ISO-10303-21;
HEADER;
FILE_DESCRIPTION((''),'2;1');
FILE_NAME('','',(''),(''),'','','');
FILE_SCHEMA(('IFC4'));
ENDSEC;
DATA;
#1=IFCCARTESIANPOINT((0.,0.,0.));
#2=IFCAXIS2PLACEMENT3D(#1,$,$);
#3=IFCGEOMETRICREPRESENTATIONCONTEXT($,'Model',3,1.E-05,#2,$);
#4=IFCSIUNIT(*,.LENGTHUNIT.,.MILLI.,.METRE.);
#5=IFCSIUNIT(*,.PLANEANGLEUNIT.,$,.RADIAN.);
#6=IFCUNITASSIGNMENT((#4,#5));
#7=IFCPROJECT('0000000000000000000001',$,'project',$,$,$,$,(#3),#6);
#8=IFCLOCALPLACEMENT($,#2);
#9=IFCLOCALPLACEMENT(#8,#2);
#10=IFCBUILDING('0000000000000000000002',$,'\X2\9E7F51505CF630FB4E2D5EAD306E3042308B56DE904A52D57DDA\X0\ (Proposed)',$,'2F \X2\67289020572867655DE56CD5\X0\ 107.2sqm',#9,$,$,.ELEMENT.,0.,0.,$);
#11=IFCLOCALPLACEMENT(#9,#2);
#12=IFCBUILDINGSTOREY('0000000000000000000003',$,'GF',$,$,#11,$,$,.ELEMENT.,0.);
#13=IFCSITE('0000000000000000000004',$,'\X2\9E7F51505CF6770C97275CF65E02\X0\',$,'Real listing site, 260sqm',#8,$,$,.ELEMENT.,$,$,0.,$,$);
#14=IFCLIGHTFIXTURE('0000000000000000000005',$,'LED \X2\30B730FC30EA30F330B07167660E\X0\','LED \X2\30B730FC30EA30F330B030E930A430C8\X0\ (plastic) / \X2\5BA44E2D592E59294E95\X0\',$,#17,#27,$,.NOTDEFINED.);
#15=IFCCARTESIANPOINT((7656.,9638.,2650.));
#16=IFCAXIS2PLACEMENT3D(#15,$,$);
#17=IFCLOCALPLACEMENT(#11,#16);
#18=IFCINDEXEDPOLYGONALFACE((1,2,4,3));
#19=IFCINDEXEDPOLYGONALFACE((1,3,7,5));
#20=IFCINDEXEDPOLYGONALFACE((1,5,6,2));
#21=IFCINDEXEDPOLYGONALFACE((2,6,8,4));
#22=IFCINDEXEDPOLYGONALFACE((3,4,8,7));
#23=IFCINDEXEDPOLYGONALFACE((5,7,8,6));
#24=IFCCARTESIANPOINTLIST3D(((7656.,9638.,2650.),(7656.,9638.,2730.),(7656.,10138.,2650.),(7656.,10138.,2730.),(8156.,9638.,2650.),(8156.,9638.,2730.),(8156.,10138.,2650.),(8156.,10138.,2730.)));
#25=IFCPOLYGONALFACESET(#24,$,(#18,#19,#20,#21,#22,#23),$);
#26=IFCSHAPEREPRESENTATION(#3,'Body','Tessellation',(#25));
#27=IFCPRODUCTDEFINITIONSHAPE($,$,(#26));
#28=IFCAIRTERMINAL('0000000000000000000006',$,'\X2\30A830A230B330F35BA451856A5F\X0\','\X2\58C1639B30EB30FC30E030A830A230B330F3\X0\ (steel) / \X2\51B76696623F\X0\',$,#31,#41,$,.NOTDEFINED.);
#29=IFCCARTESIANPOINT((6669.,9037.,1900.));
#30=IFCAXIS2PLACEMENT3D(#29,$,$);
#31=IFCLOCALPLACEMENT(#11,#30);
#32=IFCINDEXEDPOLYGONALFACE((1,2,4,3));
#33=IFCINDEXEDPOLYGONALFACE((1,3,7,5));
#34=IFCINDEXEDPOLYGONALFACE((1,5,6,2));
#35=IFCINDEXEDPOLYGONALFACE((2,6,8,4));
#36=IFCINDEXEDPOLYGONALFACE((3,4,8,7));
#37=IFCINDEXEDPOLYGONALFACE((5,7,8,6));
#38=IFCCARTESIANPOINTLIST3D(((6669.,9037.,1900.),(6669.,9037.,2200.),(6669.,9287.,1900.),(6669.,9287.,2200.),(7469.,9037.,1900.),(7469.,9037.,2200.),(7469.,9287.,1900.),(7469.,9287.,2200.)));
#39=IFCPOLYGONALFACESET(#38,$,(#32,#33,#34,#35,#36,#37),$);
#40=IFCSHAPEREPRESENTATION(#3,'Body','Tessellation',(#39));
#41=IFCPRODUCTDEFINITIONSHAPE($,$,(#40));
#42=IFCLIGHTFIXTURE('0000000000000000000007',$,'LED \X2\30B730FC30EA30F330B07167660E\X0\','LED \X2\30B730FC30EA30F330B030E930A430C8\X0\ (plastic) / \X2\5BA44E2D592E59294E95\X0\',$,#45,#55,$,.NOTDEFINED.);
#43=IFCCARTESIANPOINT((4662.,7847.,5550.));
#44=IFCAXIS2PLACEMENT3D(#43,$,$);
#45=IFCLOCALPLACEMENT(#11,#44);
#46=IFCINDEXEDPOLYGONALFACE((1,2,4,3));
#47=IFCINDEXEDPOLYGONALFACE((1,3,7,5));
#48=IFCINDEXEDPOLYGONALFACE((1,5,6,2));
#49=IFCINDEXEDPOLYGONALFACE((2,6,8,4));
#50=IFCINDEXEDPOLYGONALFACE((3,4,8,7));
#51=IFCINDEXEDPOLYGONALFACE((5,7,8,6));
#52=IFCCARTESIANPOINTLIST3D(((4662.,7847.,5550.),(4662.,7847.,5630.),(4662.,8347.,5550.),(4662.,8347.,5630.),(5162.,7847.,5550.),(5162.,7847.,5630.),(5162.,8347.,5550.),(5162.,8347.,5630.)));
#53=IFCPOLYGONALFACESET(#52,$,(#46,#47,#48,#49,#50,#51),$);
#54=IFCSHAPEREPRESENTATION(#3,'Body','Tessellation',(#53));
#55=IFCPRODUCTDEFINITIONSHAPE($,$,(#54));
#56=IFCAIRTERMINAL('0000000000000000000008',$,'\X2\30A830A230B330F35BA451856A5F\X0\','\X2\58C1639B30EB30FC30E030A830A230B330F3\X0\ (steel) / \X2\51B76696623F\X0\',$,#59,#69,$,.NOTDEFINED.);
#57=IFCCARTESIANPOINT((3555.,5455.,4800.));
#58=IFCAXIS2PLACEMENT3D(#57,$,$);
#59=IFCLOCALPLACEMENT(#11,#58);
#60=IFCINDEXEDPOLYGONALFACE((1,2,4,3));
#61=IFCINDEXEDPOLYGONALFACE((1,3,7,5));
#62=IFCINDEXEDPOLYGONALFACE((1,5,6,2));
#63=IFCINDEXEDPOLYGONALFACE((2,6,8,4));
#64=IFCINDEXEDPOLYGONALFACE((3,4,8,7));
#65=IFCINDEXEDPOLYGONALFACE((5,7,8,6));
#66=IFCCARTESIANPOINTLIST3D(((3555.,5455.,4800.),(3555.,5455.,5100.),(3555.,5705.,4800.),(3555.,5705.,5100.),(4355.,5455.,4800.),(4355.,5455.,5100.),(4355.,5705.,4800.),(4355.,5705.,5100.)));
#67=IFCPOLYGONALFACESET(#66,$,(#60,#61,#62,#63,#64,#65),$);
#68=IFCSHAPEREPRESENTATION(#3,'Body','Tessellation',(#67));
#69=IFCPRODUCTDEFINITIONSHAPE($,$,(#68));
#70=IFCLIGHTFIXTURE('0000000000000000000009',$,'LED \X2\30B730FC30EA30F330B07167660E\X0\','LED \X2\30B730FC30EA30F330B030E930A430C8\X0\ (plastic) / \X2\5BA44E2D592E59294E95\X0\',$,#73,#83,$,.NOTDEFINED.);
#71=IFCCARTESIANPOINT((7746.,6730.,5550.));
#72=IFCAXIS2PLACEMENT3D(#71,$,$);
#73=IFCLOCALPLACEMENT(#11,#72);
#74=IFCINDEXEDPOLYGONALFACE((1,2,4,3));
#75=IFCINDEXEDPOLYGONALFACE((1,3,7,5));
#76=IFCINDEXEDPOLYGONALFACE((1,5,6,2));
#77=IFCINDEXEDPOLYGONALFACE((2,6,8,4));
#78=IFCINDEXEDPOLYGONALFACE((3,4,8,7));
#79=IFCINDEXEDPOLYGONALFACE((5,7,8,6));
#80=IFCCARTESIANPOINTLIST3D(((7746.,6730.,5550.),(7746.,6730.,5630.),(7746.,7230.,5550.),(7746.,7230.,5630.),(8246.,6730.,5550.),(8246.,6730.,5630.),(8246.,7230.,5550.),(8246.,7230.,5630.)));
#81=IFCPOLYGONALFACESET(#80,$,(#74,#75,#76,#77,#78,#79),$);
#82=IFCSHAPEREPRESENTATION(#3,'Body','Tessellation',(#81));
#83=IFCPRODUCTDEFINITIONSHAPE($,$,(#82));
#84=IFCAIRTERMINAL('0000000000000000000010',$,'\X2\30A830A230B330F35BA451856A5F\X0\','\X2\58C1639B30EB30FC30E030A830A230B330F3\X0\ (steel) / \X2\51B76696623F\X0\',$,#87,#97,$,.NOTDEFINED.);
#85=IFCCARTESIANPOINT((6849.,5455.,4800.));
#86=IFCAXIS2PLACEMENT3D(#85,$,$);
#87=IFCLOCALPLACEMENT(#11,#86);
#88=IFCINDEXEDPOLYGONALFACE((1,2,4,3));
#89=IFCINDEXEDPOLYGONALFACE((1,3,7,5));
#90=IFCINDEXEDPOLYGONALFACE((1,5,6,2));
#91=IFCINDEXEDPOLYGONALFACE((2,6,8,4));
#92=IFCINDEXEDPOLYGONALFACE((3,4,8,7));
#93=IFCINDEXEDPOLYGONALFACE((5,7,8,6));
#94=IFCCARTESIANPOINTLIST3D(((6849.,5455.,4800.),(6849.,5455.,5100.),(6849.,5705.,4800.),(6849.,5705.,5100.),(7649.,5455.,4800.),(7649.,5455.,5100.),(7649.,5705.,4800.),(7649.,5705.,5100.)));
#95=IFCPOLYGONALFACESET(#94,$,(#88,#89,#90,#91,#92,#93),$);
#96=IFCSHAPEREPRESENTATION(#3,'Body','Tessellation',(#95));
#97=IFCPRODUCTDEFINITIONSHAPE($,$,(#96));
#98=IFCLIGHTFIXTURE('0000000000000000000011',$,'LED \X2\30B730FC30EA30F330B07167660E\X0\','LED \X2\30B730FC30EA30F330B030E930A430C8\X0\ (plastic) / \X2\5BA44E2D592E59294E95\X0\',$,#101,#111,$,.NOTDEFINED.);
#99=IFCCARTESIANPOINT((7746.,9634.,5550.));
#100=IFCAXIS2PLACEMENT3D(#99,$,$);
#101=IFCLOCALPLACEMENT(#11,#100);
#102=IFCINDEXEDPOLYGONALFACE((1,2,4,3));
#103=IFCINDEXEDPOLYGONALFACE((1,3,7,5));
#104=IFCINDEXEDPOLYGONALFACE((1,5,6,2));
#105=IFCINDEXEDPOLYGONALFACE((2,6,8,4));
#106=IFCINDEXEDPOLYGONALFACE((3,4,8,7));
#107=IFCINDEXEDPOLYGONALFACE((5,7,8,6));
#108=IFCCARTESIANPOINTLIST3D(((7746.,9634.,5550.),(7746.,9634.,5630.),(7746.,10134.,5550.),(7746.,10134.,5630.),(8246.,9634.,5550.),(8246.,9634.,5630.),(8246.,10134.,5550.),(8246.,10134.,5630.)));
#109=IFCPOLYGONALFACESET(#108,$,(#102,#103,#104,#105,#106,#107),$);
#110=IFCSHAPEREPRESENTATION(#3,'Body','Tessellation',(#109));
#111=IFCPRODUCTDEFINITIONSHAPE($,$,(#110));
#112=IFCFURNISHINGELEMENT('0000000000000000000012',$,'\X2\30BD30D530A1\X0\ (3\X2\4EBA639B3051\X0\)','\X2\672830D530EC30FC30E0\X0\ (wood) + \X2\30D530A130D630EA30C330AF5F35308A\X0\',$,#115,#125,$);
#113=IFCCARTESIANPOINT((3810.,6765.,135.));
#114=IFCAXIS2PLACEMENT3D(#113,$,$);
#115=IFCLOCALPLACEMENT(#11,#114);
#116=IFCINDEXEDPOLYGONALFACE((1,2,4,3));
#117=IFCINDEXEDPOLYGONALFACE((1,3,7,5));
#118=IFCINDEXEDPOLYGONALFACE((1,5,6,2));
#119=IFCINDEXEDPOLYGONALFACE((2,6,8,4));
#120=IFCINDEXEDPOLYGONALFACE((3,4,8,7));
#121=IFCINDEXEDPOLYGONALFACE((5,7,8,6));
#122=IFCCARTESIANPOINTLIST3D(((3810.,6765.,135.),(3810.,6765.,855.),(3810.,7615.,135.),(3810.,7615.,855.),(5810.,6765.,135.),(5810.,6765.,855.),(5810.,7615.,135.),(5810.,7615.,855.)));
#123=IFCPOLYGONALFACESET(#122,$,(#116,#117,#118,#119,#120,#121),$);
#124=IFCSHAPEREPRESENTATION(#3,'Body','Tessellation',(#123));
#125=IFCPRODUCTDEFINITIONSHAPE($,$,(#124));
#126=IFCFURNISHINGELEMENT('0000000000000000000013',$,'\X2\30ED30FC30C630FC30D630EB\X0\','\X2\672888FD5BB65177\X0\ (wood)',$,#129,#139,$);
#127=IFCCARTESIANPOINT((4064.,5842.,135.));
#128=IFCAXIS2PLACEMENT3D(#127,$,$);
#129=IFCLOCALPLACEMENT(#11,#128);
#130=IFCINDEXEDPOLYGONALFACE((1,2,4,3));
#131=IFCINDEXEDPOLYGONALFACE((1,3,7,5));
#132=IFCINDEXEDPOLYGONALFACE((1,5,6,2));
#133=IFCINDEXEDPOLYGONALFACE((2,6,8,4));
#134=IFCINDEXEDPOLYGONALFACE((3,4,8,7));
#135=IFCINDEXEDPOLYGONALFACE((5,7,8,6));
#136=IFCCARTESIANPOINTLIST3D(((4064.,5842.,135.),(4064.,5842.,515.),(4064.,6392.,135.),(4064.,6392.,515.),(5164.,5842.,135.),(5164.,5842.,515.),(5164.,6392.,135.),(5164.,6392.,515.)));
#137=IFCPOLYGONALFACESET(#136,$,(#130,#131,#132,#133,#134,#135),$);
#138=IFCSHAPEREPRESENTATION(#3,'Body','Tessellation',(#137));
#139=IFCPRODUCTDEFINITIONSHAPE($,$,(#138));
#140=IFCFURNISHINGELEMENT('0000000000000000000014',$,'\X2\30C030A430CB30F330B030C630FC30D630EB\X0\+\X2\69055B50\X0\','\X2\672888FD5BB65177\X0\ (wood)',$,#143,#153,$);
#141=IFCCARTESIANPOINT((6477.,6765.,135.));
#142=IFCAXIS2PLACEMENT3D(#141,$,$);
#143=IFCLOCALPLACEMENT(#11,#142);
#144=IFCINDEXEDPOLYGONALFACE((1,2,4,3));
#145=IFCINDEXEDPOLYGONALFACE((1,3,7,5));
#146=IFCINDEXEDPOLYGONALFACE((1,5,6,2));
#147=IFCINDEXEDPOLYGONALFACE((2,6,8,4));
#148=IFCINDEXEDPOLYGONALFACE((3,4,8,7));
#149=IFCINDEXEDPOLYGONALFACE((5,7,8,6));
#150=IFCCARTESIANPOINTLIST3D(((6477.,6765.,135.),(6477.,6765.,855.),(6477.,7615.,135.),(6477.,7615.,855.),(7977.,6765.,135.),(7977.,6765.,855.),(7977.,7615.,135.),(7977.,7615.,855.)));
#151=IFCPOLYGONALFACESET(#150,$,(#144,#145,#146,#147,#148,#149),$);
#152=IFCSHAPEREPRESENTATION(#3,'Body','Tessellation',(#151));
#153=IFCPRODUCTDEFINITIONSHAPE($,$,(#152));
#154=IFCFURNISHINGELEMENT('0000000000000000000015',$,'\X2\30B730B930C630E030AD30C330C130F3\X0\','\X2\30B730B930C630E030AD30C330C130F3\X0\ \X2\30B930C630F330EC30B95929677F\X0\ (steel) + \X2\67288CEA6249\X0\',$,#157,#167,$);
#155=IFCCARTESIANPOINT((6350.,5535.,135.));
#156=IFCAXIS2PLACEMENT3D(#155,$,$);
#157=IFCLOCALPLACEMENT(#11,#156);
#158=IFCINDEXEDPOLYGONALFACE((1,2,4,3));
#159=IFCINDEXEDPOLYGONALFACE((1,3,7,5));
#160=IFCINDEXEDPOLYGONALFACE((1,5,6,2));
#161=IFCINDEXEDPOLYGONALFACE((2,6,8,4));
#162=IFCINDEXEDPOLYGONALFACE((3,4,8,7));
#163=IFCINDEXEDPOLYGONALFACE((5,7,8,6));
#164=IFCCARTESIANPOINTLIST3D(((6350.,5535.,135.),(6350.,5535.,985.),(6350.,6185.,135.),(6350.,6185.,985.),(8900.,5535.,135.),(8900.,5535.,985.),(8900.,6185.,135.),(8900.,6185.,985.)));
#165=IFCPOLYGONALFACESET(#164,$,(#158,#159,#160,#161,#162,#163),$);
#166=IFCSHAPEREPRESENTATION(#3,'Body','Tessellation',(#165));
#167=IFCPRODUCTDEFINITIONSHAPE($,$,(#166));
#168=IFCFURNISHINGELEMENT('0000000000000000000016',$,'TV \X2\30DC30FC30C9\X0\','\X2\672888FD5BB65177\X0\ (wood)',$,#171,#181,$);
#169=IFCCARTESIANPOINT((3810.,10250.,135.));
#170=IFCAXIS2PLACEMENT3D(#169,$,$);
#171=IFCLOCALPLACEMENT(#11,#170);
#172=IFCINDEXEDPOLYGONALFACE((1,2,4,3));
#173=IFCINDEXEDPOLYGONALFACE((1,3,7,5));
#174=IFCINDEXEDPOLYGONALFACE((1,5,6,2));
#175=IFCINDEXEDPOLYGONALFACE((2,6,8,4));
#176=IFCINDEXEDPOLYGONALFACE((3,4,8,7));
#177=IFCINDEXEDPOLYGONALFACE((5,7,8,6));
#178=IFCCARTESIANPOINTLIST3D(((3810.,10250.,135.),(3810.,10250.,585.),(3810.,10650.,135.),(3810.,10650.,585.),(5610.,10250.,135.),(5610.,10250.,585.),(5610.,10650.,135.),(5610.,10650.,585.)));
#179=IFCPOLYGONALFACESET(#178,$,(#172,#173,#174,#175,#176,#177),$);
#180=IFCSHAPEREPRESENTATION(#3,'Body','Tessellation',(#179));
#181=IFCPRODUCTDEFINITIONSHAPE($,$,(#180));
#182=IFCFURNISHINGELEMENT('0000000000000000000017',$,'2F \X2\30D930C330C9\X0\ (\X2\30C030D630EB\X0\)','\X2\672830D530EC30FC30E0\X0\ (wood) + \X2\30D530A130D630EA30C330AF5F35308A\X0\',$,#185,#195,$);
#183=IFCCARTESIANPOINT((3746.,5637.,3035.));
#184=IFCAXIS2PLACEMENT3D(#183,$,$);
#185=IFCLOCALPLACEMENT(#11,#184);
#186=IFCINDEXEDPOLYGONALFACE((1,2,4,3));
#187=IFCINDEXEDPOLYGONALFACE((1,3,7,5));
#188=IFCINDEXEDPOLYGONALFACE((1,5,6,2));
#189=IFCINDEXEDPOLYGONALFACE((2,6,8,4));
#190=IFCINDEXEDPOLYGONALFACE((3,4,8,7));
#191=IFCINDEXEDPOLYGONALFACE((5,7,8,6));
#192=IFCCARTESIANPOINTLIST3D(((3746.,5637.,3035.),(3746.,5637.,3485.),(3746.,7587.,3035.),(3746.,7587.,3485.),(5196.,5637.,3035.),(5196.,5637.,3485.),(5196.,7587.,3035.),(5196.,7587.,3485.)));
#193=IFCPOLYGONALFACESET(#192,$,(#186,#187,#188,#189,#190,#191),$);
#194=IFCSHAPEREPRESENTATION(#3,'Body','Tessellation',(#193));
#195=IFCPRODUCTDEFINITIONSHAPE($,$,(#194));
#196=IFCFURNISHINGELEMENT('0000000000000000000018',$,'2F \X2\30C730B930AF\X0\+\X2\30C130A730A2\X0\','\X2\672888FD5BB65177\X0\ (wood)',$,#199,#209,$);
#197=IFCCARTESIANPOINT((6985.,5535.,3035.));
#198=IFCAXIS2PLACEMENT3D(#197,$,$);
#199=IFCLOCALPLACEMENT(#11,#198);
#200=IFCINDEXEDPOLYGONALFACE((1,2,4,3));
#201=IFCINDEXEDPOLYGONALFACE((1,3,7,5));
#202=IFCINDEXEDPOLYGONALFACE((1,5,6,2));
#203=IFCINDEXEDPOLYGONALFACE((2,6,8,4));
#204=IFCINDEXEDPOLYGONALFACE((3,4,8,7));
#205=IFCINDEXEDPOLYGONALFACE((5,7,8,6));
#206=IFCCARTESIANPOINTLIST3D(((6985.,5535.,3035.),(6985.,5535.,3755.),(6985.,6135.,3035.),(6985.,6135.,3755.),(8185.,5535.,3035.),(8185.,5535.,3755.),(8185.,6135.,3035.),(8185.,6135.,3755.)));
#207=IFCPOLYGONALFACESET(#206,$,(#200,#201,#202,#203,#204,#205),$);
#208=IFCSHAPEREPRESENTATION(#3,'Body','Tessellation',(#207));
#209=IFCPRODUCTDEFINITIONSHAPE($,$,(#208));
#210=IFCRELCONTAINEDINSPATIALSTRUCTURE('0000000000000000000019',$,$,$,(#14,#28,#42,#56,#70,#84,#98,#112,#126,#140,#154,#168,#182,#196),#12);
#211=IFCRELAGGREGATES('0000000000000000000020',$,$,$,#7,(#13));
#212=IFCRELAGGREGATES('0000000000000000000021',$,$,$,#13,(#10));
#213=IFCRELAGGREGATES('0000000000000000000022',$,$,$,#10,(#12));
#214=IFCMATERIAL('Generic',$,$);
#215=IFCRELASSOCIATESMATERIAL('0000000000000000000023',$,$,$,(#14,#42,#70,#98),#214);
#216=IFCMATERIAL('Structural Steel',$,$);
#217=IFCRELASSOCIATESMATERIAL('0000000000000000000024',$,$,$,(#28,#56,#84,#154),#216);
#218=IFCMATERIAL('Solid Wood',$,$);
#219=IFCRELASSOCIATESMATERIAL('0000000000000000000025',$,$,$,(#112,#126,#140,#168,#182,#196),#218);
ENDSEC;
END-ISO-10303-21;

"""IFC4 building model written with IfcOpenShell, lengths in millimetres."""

from ifc_helpers import new_model, si_unit, frame, frame_2d, origin, place, context, project, spatial, rectangle, extrude, material, element, save


model = new_model("IFC4")

# Units and contexts
model_context = context("Model", 3, precision=1e-05, world=origin())
ifc_project = project(units=[si_unit("LENGTHUNIT", "METRE", prefix="MILLI"), si_unit("PLANEANGLEUNIT", "RADIAN")], contexts=[model_context])

# Site, building, storey
site_placement = place(None, origin())
site = spatial("IfcSite", under=ifc_project, at=site_placement, Name="鹿児島県霧島市", ObjectType="Real listing site, 260sqm", CompositionType="ELEMENT", RefElevation=0.0)
building_placement = place(site_placement, origin())
building = spatial("IfcBuilding", under=site, at=building_placement, Name="鹿児島・中庭のある回遊動線 (Proposed)", ObjectType="2F 木造在来工法 107.2sqm", CompositionType="ELEMENT", ElevationOfRefHeight=0.0, ElevationOfTerrain=0.0)
storey_placement = place(building_placement, origin())
storey = spatial("IfcBuildingStorey", under=building, at=storey_placement, Name="GF", CompositionType="ELEMENT", Elevation=0.0)

# Shared definitions
ifc_material_1 = material(Name="Solid Wood")

# Shared definitions
ifc_material_2 = material(Name="Structural Steel")

# Shared definitions
ifc_material_3 = material(Name="Generic")

# Light fixture
light_fixture_1_placement = place(storey_placement, frame((7656.0, 9638.0, 2650.0)))
element("IfcLightFixture", 1, at=light_fixture_1_placement, inside=storey, material=ifc_material_3, Name="LED シーリング照明", Description="LED シーリングライト (plastic) / 室中央天井", PredefinedType="NOTDEFINED", context=model_context, shape_type="SweptSolid", body=[
    extrude(rectangle(XDim=500.0, YDim=500.0, at=frame_2d((250.0, 250.0))), frame((7656.0, 9638.0, 2650.0)), (0.0, 0.0, 1.0), 80.0),
])

# Air terminal
air_terminal_1_placement = place(storey_placement, frame((6669.0, 9037.0, 1900.0)))
element("IfcAirTerminal", 2, at=air_terminal_1_placement, inside=storey, material=ifc_material_2, Name="エアコン室内機", Description="壁掛ルームエアコン (steel) / 冷暖房", PredefinedType="NOTDEFINED", context=model_context, shape_type="SweptSolid", body=[
    extrude(rectangle(XDim=800.0, YDim=250.0, at=frame_2d((400.0, 125.0))), frame((6669.0, 9037.0, 1900.0)), (0.0, 0.0, 1.0), 300.0),
])

# Light fixture
light_fixture_2_placement = place(storey_placement, frame((4662.0, 7847.0, 5550.0)))
element("IfcLightFixture", 3, at=light_fixture_2_placement, inside=storey, material=ifc_material_3, Name="LED シーリング照明", Description="LED シーリングライト (plastic) / 室中央天井", PredefinedType="NOTDEFINED", context=model_context, shape_type="SweptSolid", body=[
    extrude(rectangle(XDim=500.0, YDim=500.0, at=frame_2d((250.0, 250.0))), frame((4662.0, 7847.0, 5550.0)), (0.0, 0.0, 1.0), 80.0),
])

# Air terminal
air_terminal_2_placement = place(storey_placement, frame((3555.0, 5455.0, 4800.0)))
element("IfcAirTerminal", 4, at=air_terminal_2_placement, inside=storey, material=ifc_material_2, Name="エアコン室内機", Description="壁掛ルームエアコン (steel) / 冷暖房", PredefinedType="NOTDEFINED", context=model_context, shape_type="SweptSolid", body=[
    extrude(rectangle(XDim=800.0, YDim=250.0, at=frame_2d((400.0, 125.0))), frame((3555.0, 5455.0, 4800.0)), (0.0, 0.0, 1.0), 300.0),
])

# Light fixture
light_fixture_3_placement = place(storey_placement, frame((7746.0, 6730.0, 5550.0)))
element("IfcLightFixture", 5, at=light_fixture_3_placement, inside=storey, material=ifc_material_3, Name="LED シーリング照明", Description="LED シーリングライト (plastic) / 室中央天井", PredefinedType="NOTDEFINED", context=model_context, shape_type="SweptSolid", body=[
    extrude(rectangle(XDim=500.0, YDim=500.0, at=frame_2d((250.0, 250.0))), frame((7746.0, 6730.0, 5550.0)), (0.0, 0.0, 1.0), 80.0),
])

# Air terminal
air_terminal_3_placement = place(storey_placement, frame((6849.0, 5455.0, 4800.0)))
element("IfcAirTerminal", 6, at=air_terminal_3_placement, inside=storey, material=ifc_material_2, Name="エアコン室内機", Description="壁掛ルームエアコン (steel) / 冷暖房", PredefinedType="NOTDEFINED", context=model_context, shape_type="SweptSolid", body=[
    extrude(rectangle(XDim=800.0, YDim=250.0, at=frame_2d((400.0, 125.0))), frame((6849.0, 5455.0, 4800.0)), (0.0, 0.0, 1.0), 300.0),
])

# Light fixture
light_fixture_4_placement = place(storey_placement, frame((7746.0, 9634.0, 5550.0)))
element("IfcLightFixture", 7, at=light_fixture_4_placement, inside=storey, material=ifc_material_3, Name="LED シーリング照明", Description="LED シーリングライト (plastic) / 室中央天井", PredefinedType="NOTDEFINED", context=model_context, shape_type="SweptSolid", body=[
    extrude(rectangle(XDim=500.0, YDim=500.0, at=frame_2d((250.0, 250.0))), frame((7746.0, 9634.0, 5550.0)), (0.0, 0.0, 1.0), 80.0),
])

# Furnishing elements
furnishing_1_placement = place(storey_placement, frame((3810.0, 6765.0, 135.0)))
element("IfcFurnishingElement", 8, at=furnishing_1_placement, inside=storey, material=ifc_material_1, Name="ソファ (3人掛け)", Description="木フレーム (wood) + ファブリック張り", context=model_context, shape_type="SweptSolid", body=[
    extrude(rectangle(XDim=2000.0, YDim=850.0, at=frame_2d((1000.0, 425.0))), frame((3810.0, 6765.0, 135.0)), (0.0, 0.0, 1.0), 720.0),
])
furnishing_2_placement = place(storey_placement, frame((4064.0, 5842.0, 135.0)))
element("IfcFurnishingElement", 9, at=furnishing_2_placement, inside=storey, material=ifc_material_1, Name="ローテーブル", Description="木製家具 (wood)", context=model_context, shape_type="SweptSolid", body=[
    extrude(rectangle(XDim=1100.0, YDim=550.0, at=frame_2d((550.0, 275.0))), frame((4064.0, 5842.0, 135.0)), (0.0, 0.0, 1.0), 380.0),
])
furnishing_3_placement = place(storey_placement, frame((6477.0, 6765.0, 135.0)))
element("IfcFurnishingElement", 10, at=furnishing_3_placement, inside=storey, material=ifc_material_1, Name="ダイニングテーブル+椅子", Description="木製家具 (wood)", context=model_context, shape_type="SweptSolid", body=[
    extrude(rectangle(XDim=1500.0, YDim=850.0, at=frame_2d((750.0, 425.0))), frame((6477.0, 6765.0, 135.0)), (0.0, 0.0, 1.0), 720.0),
])
furnishing_4_placement = place(storey_placement, frame((6350.0, 5535.0, 135.0)))
element("IfcFurnishingElement", 11, at=furnishing_4_placement, inside=storey, material=ifc_material_2, Name="システムキッチン", Description="システムキッチン ステンレス天板 (steel) + 木質扉", context=model_context, shape_type="SweptSolid", body=[
    extrude(rectangle(XDim=2550.0, YDim=650.0, at=frame_2d((1275.0, 325.0))), frame((6350.0, 5535.0, 135.0)), (0.0, 0.0, 1.0), 850.0),
])
furnishing_5_placement = place(storey_placement, frame((3810.0, 10250.0, 135.0)))
element("IfcFurnishingElement", 12, at=furnishing_5_placement, inside=storey, material=ifc_material_1, Name="TV ボード", Description="木製家具 (wood)", context=model_context, shape_type="SweptSolid", body=[
    extrude(rectangle(XDim=1800.0, YDim=400.0, at=frame_2d((900.0, 200.0))), frame((3810.0, 10250.0, 135.0)), (0.0, 0.0, 1.0), 450.0),
])
furnishing_6_placement = place(storey_placement, frame((3746.0, 5637.0, 3035.0)))
element("IfcFurnishingElement", 13, at=furnishing_6_placement, inside=storey, material=ifc_material_1, Name="2F ベッド (ダブル)", Description="木フレーム (wood) + ファブリック張り", context=model_context, shape_type="SweptSolid", body=[
    extrude(rectangle(XDim=1450.0, YDim=1950.0, at=frame_2d((725.0, 975.0))), frame((3746.0, 5637.0, 3035.0)), (0.0, 0.0, 1.0), 450.0),
])
furnishing_7_placement = place(storey_placement, frame((6985.0, 5535.0, 3035.0)))
element("IfcFurnishingElement", 14, at=furnishing_7_placement, inside=storey, material=ifc_material_1, Name="2F デスク+チェア", Description="木製家具 (wood)", context=model_context, shape_type="SweptSolid", body=[
    extrude(rectangle(XDim=1200.0, YDim=600.0, at=frame_2d((600.0, 300.0))), frame((6985.0, 5535.0, 3035.0)), (0.0, 0.0, 1.0), 720.0),
])

save(model, "model.ifc")
